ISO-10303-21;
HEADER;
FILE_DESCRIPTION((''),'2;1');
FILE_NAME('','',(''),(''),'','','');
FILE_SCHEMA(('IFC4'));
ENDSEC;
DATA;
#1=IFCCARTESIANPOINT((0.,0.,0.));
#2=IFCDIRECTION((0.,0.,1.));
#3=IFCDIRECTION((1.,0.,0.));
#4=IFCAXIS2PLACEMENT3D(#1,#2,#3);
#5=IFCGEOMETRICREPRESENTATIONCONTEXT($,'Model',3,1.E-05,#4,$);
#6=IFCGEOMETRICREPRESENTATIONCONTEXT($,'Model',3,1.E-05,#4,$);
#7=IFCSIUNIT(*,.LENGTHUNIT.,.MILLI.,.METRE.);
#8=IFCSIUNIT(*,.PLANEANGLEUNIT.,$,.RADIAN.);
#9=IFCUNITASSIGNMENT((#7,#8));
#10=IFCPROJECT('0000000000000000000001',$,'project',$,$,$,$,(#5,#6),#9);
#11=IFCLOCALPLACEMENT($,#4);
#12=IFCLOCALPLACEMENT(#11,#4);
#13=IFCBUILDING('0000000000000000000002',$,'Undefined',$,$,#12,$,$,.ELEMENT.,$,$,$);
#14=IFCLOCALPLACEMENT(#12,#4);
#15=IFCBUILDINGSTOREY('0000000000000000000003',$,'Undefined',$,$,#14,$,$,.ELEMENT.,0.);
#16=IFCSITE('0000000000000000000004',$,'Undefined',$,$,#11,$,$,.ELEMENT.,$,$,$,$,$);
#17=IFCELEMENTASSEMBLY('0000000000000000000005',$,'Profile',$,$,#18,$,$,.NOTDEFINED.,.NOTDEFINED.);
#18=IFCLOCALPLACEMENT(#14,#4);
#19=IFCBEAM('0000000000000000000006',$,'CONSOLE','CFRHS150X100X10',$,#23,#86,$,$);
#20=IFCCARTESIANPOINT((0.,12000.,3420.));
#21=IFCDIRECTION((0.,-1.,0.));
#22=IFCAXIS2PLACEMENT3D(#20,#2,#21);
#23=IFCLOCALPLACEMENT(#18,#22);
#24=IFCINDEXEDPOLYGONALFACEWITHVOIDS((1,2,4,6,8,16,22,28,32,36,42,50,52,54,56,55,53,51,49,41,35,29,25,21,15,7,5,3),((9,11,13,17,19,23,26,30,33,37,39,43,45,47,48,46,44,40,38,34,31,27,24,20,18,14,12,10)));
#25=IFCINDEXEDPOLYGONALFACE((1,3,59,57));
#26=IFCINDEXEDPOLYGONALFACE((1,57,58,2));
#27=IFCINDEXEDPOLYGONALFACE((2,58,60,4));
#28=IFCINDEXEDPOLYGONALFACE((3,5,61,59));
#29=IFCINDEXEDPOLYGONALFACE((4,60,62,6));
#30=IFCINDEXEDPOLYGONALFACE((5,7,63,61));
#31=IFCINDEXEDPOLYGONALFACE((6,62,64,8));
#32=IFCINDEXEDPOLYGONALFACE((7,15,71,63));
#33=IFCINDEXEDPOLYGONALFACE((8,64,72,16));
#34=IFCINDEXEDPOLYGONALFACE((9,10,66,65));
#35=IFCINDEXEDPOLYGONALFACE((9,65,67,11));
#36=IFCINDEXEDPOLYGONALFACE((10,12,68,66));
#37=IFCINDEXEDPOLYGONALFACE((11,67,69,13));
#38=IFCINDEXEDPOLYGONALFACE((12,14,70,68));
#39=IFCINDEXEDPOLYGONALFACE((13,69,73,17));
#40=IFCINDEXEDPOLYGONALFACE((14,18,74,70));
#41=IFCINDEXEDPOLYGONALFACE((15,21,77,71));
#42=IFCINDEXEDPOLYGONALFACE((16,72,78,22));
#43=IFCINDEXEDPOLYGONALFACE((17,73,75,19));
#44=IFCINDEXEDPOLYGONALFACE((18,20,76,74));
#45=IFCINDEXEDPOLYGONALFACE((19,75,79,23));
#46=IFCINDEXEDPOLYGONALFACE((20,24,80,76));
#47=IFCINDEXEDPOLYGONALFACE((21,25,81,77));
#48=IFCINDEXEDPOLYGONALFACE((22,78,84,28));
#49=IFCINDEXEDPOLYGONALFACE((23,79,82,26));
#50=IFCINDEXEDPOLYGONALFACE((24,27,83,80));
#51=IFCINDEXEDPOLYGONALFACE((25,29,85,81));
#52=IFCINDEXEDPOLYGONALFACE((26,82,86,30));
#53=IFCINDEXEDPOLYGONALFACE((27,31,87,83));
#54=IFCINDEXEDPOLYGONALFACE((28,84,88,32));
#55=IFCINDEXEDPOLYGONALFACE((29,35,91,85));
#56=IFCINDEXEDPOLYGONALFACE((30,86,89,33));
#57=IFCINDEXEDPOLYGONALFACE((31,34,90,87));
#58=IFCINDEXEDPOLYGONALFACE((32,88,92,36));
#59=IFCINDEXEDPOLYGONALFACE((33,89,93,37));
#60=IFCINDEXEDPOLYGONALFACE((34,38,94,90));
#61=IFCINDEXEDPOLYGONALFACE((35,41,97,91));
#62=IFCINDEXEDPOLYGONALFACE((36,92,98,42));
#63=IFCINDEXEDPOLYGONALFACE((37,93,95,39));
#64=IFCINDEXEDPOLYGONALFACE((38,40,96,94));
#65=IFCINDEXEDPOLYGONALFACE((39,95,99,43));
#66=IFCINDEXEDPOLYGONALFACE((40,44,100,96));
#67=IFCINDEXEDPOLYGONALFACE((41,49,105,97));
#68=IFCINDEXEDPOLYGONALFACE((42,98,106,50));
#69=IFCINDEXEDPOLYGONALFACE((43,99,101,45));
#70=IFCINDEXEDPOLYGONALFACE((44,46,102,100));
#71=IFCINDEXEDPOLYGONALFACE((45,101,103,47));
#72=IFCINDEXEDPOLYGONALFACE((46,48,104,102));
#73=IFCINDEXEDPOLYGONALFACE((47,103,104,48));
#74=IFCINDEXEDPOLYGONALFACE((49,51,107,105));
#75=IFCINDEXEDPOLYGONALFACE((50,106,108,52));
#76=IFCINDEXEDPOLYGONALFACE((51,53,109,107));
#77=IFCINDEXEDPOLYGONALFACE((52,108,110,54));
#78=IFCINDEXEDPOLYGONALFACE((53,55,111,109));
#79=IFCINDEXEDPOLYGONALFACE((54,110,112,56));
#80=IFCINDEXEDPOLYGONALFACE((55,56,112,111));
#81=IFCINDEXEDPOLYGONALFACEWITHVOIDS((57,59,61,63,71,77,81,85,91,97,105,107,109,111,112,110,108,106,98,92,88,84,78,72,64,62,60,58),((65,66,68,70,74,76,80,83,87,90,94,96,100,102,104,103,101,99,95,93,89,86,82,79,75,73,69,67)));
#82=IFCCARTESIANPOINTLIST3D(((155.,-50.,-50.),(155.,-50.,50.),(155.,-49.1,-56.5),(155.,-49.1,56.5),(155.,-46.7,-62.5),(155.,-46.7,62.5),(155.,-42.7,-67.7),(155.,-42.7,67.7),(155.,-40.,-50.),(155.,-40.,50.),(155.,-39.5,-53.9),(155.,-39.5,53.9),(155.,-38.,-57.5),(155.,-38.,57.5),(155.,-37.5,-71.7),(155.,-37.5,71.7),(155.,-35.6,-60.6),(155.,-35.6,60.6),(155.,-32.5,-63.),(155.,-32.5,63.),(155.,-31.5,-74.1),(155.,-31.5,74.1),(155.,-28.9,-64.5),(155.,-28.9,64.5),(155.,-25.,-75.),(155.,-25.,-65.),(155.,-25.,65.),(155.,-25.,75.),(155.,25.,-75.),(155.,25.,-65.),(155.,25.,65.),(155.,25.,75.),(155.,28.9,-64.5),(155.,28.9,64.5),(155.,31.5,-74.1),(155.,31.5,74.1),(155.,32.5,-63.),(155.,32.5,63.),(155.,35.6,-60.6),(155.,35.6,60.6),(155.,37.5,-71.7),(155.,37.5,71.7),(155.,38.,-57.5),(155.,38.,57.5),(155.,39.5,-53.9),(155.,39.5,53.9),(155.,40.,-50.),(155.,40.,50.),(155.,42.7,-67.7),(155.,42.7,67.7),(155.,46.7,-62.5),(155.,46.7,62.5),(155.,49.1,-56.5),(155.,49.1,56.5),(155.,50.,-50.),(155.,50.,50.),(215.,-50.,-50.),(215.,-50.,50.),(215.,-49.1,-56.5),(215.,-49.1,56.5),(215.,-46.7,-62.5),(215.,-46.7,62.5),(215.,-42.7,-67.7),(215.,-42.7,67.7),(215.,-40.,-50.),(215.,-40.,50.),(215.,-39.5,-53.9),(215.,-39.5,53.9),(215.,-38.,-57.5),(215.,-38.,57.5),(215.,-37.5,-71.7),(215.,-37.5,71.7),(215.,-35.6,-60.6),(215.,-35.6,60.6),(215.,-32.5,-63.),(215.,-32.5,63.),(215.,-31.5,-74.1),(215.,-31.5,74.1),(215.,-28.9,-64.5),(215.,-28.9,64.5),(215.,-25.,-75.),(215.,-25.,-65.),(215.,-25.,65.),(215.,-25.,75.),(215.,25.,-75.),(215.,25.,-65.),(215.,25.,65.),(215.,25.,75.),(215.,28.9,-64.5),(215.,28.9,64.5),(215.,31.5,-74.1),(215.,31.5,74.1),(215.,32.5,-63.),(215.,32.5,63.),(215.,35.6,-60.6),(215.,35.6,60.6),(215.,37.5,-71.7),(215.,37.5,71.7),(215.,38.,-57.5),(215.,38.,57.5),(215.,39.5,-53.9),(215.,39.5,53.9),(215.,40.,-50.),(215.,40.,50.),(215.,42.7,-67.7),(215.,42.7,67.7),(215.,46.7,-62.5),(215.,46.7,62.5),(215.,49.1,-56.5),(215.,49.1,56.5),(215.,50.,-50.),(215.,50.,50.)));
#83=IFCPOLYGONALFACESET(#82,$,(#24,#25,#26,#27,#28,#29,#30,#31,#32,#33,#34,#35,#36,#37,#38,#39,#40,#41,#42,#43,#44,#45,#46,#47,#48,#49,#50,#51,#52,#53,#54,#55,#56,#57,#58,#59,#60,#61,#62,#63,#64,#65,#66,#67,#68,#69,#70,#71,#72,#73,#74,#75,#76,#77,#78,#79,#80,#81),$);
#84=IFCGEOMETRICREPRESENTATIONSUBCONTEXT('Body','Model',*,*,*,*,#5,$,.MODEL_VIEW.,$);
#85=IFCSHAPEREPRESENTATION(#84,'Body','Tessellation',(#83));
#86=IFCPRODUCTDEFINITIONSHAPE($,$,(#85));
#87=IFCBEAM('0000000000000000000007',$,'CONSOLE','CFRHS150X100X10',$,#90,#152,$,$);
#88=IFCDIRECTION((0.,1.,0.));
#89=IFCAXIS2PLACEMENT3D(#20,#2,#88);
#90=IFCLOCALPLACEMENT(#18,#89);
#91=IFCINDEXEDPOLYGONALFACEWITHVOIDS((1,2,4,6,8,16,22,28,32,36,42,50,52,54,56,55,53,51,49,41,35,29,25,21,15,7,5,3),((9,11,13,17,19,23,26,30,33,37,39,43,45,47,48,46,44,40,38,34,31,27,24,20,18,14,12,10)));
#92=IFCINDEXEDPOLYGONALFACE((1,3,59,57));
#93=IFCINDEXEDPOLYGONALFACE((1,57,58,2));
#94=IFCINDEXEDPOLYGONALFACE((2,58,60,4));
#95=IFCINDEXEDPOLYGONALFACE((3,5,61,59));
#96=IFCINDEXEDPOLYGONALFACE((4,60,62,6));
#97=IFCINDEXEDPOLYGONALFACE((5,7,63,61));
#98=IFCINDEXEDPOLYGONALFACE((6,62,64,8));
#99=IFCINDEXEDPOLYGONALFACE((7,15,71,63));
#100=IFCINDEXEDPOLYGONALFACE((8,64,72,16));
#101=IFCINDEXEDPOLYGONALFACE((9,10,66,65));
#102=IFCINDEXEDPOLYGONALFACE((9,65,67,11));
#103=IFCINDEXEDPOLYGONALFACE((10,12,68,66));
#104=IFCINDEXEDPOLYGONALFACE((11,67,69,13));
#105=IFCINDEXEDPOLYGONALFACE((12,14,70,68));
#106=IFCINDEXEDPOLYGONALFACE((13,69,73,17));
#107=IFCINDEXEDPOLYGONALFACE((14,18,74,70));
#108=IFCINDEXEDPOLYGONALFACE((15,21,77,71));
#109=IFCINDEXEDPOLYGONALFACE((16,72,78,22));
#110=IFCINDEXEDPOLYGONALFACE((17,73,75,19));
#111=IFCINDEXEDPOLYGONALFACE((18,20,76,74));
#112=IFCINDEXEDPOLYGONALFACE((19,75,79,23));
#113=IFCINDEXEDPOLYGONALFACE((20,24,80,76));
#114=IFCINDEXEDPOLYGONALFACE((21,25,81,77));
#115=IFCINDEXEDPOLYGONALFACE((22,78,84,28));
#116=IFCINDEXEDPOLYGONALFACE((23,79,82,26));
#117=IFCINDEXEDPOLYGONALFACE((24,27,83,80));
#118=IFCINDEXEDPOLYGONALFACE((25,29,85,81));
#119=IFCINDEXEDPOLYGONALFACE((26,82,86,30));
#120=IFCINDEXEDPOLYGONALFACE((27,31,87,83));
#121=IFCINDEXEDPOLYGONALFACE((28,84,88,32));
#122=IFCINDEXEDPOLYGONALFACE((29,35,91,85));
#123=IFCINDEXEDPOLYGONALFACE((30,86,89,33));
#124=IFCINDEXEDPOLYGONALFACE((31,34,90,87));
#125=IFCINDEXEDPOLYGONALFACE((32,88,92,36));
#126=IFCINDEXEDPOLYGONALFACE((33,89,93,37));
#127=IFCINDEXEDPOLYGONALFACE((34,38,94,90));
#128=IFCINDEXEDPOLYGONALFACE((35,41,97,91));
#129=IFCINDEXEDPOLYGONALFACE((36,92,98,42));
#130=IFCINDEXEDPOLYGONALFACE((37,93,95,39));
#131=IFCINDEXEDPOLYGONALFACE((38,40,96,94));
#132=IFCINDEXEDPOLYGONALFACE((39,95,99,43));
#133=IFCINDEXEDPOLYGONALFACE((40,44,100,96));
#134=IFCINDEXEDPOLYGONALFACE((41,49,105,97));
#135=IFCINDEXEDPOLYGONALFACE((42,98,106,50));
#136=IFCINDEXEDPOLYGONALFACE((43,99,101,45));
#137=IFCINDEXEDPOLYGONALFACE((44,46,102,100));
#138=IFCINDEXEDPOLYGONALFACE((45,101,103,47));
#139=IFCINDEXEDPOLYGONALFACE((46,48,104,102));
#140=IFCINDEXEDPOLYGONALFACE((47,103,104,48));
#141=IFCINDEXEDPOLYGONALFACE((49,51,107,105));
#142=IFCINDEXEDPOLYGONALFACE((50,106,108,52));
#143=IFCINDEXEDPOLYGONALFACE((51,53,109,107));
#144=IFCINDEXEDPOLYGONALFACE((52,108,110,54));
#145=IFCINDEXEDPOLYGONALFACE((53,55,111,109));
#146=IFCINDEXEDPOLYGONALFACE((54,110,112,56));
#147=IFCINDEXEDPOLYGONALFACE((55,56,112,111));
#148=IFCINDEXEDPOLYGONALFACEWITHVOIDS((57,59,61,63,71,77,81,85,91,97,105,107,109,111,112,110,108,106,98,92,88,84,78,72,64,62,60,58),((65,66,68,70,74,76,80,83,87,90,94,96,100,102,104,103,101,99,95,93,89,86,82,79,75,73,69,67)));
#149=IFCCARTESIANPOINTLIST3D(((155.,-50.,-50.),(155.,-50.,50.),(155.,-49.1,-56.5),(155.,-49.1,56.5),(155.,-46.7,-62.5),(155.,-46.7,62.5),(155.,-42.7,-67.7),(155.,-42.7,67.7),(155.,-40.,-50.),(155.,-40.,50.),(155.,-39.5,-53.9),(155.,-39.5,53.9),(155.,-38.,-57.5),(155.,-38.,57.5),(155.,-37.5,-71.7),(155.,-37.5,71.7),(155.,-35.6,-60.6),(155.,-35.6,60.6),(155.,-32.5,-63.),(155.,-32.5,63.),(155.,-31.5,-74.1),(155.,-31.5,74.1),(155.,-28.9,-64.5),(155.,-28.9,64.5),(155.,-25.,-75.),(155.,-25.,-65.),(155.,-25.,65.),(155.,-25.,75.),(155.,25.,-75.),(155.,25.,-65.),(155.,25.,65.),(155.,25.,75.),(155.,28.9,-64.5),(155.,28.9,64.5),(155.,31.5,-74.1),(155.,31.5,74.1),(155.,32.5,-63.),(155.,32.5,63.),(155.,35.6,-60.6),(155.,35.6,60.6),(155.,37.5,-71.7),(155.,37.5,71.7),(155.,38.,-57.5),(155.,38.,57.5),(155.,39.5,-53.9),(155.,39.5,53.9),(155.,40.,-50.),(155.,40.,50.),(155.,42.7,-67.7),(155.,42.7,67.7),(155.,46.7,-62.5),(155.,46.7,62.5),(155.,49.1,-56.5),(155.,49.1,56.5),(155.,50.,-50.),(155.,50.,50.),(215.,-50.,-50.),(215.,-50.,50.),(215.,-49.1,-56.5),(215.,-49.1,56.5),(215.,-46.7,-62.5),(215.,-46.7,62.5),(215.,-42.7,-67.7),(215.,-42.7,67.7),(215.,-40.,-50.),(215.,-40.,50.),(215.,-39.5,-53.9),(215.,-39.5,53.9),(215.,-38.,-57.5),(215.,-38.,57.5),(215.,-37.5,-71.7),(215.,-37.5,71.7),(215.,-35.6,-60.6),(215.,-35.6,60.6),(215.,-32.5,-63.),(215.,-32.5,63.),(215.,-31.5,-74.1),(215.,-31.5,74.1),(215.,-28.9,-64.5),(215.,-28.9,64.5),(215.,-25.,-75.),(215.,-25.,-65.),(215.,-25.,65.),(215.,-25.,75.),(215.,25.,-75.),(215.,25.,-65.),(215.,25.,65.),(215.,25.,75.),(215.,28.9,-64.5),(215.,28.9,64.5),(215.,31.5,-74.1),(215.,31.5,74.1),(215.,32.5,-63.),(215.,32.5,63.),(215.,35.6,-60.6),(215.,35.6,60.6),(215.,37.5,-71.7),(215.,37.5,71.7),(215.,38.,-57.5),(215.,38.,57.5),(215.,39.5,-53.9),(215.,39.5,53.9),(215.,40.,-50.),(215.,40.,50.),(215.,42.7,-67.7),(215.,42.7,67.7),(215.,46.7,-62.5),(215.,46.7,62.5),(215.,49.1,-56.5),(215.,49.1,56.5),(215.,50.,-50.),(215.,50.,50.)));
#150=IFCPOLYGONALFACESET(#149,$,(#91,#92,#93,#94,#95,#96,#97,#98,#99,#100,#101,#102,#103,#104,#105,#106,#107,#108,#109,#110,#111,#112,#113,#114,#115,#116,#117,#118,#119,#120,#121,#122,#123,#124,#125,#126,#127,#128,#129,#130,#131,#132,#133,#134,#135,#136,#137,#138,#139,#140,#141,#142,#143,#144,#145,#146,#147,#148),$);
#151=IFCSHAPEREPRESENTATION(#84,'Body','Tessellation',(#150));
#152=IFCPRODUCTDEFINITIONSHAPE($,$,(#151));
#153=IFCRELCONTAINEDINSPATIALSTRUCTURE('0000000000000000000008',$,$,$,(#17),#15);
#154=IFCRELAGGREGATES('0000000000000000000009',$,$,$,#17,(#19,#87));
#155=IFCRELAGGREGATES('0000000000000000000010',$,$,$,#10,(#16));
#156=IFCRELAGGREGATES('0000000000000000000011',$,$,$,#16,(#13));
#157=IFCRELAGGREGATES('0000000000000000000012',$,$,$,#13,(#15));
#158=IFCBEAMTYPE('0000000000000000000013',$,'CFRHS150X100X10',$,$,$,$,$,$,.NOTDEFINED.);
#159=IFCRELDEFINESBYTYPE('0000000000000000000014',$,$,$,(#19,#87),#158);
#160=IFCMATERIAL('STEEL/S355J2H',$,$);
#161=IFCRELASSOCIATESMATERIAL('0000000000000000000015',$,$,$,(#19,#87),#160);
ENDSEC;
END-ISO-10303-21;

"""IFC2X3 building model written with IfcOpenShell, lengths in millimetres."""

from ifc_helpers import new_model, si_unit, frame, origin_with_axes, origin_2d_with_axis, place, context, subcontext, project, spatial, hollow_rectangle, extrude, clip, halfspace, material, type_object, element, aggregate, save


model = new_model("IFC2X3")

# Units and contexts
model_context_1 = context("Model", 3, precision=1e-05, world=origin_with_axes())
model_context_2 = context("Model", 3, precision=1e-05, world=origin_with_axes())
body_context = subcontext(model_context_1, "Body", "Model", "MODEL_VIEW")
ifc_project = project(units=[si_unit("LENGTHUNIT", "METRE", prefix="MILLI"), si_unit("PLANEANGLEUNIT", "RADIAN")], contexts=[model_context_1, model_context_2])

# Site, building, storey
site_placement = place(None, origin_with_axes())
site = spatial("IfcSite", under=ifc_project, at=site_placement, Name="Undefined", CompositionType="ELEMENT")
building_placement = place(site_placement, origin_with_axes())
building = spatial("IfcBuilding", under=site, at=building_placement, Name="Undefined", CompositionType="ELEMENT")
storey_placement = place(building_placement, origin_with_axes())
storey = spatial("IfcBuildingStorey", under=building, at=storey_placement, Name="Undefined", CompositionType="ELEMENT", Elevation=0.0)

# Element assembly, beams
assembly_1_placement = place(storey_placement, origin_with_axes())
assembly_1 = element("IfcElementAssembly", 1, at=assembly_1_placement, inside=storey, Name="Profile", AssemblyPlace="NOTDEFINED", PredefinedType="NOTDEFINED")
ifc_material_1 = material(Name="STEEL/S355J2H")
beam_type_1 = type_object("IfcBeamType", Name="CFRHS150X100X10", PredefinedType="NOTDEFINED")
beam_1_placement = place(assembly_1_placement, frame((0.0, 12000.0, 3420.0), z_axis=(0.0, 0.0, 1.0), x_axis=(0.0, -1.0, 0.0)))
beam_1 = element("IfcBeam", 2, at=beam_1_placement, type_object=beam_type_1, material=ifc_material_1, Name="CONSOLE", Description="CFRHS150X100X10", context=body_context, shape_type="Clipping", body=[
    clip(extrude(hollow_rectangle(XDim=100.0, YDim=150.0, WallThickness=10.0, InnerFilletRadius=15.0, OuterFilletRadius=25.0, at=origin_2d_with_axis()), frame((215.0, 0.0, 0.0), z_axis=(-1.0, 0.0, 0.0), x_axis=(0.0, -1.0, 0.0)), (0.0, 0.0, 1.0), 215.0), halfspace(frame((155.0, 50.0, -75.0), z_axis=(-1.0, 0.0, 0.0), x_axis=(0.0, 0.0, 1.0)), False)),
])
beam_2_placement = place(assembly_1_placement, frame((0.0, 12000.0, 3420.0), z_axis=(0.0, 0.0, 1.0), x_axis=(0.0, 1.0, 0.0)))
beam_2 = element("IfcBeam", 3, at=beam_2_placement, type_object=beam_type_1, material=ifc_material_1, Name="CONSOLE", Description="CFRHS150X100X10", context=body_context, shape_type="Clipping", body=[
    clip(extrude(hollow_rectangle(XDim=100.0, YDim=150.0, WallThickness=10.0, InnerFilletRadius=15.0, OuterFilletRadius=25.0, at=origin_2d_with_axis()), frame((215.0, 0.0, 0.0), z_axis=(-1.0, 0.0, 0.0), x_axis=(0.0, -1.0, 0.0)), (0.0, 0.0, 1.0), 215.0), halfspace(frame((155.0, 50.0, -75.0), z_axis=(-1.0, 0.0, 0.0), x_axis=(0.0, 0.0, 1.0)), False)),
])

aggregate(assembly_1, [beam_1, beam_2])

save(model, "model.ifc")
